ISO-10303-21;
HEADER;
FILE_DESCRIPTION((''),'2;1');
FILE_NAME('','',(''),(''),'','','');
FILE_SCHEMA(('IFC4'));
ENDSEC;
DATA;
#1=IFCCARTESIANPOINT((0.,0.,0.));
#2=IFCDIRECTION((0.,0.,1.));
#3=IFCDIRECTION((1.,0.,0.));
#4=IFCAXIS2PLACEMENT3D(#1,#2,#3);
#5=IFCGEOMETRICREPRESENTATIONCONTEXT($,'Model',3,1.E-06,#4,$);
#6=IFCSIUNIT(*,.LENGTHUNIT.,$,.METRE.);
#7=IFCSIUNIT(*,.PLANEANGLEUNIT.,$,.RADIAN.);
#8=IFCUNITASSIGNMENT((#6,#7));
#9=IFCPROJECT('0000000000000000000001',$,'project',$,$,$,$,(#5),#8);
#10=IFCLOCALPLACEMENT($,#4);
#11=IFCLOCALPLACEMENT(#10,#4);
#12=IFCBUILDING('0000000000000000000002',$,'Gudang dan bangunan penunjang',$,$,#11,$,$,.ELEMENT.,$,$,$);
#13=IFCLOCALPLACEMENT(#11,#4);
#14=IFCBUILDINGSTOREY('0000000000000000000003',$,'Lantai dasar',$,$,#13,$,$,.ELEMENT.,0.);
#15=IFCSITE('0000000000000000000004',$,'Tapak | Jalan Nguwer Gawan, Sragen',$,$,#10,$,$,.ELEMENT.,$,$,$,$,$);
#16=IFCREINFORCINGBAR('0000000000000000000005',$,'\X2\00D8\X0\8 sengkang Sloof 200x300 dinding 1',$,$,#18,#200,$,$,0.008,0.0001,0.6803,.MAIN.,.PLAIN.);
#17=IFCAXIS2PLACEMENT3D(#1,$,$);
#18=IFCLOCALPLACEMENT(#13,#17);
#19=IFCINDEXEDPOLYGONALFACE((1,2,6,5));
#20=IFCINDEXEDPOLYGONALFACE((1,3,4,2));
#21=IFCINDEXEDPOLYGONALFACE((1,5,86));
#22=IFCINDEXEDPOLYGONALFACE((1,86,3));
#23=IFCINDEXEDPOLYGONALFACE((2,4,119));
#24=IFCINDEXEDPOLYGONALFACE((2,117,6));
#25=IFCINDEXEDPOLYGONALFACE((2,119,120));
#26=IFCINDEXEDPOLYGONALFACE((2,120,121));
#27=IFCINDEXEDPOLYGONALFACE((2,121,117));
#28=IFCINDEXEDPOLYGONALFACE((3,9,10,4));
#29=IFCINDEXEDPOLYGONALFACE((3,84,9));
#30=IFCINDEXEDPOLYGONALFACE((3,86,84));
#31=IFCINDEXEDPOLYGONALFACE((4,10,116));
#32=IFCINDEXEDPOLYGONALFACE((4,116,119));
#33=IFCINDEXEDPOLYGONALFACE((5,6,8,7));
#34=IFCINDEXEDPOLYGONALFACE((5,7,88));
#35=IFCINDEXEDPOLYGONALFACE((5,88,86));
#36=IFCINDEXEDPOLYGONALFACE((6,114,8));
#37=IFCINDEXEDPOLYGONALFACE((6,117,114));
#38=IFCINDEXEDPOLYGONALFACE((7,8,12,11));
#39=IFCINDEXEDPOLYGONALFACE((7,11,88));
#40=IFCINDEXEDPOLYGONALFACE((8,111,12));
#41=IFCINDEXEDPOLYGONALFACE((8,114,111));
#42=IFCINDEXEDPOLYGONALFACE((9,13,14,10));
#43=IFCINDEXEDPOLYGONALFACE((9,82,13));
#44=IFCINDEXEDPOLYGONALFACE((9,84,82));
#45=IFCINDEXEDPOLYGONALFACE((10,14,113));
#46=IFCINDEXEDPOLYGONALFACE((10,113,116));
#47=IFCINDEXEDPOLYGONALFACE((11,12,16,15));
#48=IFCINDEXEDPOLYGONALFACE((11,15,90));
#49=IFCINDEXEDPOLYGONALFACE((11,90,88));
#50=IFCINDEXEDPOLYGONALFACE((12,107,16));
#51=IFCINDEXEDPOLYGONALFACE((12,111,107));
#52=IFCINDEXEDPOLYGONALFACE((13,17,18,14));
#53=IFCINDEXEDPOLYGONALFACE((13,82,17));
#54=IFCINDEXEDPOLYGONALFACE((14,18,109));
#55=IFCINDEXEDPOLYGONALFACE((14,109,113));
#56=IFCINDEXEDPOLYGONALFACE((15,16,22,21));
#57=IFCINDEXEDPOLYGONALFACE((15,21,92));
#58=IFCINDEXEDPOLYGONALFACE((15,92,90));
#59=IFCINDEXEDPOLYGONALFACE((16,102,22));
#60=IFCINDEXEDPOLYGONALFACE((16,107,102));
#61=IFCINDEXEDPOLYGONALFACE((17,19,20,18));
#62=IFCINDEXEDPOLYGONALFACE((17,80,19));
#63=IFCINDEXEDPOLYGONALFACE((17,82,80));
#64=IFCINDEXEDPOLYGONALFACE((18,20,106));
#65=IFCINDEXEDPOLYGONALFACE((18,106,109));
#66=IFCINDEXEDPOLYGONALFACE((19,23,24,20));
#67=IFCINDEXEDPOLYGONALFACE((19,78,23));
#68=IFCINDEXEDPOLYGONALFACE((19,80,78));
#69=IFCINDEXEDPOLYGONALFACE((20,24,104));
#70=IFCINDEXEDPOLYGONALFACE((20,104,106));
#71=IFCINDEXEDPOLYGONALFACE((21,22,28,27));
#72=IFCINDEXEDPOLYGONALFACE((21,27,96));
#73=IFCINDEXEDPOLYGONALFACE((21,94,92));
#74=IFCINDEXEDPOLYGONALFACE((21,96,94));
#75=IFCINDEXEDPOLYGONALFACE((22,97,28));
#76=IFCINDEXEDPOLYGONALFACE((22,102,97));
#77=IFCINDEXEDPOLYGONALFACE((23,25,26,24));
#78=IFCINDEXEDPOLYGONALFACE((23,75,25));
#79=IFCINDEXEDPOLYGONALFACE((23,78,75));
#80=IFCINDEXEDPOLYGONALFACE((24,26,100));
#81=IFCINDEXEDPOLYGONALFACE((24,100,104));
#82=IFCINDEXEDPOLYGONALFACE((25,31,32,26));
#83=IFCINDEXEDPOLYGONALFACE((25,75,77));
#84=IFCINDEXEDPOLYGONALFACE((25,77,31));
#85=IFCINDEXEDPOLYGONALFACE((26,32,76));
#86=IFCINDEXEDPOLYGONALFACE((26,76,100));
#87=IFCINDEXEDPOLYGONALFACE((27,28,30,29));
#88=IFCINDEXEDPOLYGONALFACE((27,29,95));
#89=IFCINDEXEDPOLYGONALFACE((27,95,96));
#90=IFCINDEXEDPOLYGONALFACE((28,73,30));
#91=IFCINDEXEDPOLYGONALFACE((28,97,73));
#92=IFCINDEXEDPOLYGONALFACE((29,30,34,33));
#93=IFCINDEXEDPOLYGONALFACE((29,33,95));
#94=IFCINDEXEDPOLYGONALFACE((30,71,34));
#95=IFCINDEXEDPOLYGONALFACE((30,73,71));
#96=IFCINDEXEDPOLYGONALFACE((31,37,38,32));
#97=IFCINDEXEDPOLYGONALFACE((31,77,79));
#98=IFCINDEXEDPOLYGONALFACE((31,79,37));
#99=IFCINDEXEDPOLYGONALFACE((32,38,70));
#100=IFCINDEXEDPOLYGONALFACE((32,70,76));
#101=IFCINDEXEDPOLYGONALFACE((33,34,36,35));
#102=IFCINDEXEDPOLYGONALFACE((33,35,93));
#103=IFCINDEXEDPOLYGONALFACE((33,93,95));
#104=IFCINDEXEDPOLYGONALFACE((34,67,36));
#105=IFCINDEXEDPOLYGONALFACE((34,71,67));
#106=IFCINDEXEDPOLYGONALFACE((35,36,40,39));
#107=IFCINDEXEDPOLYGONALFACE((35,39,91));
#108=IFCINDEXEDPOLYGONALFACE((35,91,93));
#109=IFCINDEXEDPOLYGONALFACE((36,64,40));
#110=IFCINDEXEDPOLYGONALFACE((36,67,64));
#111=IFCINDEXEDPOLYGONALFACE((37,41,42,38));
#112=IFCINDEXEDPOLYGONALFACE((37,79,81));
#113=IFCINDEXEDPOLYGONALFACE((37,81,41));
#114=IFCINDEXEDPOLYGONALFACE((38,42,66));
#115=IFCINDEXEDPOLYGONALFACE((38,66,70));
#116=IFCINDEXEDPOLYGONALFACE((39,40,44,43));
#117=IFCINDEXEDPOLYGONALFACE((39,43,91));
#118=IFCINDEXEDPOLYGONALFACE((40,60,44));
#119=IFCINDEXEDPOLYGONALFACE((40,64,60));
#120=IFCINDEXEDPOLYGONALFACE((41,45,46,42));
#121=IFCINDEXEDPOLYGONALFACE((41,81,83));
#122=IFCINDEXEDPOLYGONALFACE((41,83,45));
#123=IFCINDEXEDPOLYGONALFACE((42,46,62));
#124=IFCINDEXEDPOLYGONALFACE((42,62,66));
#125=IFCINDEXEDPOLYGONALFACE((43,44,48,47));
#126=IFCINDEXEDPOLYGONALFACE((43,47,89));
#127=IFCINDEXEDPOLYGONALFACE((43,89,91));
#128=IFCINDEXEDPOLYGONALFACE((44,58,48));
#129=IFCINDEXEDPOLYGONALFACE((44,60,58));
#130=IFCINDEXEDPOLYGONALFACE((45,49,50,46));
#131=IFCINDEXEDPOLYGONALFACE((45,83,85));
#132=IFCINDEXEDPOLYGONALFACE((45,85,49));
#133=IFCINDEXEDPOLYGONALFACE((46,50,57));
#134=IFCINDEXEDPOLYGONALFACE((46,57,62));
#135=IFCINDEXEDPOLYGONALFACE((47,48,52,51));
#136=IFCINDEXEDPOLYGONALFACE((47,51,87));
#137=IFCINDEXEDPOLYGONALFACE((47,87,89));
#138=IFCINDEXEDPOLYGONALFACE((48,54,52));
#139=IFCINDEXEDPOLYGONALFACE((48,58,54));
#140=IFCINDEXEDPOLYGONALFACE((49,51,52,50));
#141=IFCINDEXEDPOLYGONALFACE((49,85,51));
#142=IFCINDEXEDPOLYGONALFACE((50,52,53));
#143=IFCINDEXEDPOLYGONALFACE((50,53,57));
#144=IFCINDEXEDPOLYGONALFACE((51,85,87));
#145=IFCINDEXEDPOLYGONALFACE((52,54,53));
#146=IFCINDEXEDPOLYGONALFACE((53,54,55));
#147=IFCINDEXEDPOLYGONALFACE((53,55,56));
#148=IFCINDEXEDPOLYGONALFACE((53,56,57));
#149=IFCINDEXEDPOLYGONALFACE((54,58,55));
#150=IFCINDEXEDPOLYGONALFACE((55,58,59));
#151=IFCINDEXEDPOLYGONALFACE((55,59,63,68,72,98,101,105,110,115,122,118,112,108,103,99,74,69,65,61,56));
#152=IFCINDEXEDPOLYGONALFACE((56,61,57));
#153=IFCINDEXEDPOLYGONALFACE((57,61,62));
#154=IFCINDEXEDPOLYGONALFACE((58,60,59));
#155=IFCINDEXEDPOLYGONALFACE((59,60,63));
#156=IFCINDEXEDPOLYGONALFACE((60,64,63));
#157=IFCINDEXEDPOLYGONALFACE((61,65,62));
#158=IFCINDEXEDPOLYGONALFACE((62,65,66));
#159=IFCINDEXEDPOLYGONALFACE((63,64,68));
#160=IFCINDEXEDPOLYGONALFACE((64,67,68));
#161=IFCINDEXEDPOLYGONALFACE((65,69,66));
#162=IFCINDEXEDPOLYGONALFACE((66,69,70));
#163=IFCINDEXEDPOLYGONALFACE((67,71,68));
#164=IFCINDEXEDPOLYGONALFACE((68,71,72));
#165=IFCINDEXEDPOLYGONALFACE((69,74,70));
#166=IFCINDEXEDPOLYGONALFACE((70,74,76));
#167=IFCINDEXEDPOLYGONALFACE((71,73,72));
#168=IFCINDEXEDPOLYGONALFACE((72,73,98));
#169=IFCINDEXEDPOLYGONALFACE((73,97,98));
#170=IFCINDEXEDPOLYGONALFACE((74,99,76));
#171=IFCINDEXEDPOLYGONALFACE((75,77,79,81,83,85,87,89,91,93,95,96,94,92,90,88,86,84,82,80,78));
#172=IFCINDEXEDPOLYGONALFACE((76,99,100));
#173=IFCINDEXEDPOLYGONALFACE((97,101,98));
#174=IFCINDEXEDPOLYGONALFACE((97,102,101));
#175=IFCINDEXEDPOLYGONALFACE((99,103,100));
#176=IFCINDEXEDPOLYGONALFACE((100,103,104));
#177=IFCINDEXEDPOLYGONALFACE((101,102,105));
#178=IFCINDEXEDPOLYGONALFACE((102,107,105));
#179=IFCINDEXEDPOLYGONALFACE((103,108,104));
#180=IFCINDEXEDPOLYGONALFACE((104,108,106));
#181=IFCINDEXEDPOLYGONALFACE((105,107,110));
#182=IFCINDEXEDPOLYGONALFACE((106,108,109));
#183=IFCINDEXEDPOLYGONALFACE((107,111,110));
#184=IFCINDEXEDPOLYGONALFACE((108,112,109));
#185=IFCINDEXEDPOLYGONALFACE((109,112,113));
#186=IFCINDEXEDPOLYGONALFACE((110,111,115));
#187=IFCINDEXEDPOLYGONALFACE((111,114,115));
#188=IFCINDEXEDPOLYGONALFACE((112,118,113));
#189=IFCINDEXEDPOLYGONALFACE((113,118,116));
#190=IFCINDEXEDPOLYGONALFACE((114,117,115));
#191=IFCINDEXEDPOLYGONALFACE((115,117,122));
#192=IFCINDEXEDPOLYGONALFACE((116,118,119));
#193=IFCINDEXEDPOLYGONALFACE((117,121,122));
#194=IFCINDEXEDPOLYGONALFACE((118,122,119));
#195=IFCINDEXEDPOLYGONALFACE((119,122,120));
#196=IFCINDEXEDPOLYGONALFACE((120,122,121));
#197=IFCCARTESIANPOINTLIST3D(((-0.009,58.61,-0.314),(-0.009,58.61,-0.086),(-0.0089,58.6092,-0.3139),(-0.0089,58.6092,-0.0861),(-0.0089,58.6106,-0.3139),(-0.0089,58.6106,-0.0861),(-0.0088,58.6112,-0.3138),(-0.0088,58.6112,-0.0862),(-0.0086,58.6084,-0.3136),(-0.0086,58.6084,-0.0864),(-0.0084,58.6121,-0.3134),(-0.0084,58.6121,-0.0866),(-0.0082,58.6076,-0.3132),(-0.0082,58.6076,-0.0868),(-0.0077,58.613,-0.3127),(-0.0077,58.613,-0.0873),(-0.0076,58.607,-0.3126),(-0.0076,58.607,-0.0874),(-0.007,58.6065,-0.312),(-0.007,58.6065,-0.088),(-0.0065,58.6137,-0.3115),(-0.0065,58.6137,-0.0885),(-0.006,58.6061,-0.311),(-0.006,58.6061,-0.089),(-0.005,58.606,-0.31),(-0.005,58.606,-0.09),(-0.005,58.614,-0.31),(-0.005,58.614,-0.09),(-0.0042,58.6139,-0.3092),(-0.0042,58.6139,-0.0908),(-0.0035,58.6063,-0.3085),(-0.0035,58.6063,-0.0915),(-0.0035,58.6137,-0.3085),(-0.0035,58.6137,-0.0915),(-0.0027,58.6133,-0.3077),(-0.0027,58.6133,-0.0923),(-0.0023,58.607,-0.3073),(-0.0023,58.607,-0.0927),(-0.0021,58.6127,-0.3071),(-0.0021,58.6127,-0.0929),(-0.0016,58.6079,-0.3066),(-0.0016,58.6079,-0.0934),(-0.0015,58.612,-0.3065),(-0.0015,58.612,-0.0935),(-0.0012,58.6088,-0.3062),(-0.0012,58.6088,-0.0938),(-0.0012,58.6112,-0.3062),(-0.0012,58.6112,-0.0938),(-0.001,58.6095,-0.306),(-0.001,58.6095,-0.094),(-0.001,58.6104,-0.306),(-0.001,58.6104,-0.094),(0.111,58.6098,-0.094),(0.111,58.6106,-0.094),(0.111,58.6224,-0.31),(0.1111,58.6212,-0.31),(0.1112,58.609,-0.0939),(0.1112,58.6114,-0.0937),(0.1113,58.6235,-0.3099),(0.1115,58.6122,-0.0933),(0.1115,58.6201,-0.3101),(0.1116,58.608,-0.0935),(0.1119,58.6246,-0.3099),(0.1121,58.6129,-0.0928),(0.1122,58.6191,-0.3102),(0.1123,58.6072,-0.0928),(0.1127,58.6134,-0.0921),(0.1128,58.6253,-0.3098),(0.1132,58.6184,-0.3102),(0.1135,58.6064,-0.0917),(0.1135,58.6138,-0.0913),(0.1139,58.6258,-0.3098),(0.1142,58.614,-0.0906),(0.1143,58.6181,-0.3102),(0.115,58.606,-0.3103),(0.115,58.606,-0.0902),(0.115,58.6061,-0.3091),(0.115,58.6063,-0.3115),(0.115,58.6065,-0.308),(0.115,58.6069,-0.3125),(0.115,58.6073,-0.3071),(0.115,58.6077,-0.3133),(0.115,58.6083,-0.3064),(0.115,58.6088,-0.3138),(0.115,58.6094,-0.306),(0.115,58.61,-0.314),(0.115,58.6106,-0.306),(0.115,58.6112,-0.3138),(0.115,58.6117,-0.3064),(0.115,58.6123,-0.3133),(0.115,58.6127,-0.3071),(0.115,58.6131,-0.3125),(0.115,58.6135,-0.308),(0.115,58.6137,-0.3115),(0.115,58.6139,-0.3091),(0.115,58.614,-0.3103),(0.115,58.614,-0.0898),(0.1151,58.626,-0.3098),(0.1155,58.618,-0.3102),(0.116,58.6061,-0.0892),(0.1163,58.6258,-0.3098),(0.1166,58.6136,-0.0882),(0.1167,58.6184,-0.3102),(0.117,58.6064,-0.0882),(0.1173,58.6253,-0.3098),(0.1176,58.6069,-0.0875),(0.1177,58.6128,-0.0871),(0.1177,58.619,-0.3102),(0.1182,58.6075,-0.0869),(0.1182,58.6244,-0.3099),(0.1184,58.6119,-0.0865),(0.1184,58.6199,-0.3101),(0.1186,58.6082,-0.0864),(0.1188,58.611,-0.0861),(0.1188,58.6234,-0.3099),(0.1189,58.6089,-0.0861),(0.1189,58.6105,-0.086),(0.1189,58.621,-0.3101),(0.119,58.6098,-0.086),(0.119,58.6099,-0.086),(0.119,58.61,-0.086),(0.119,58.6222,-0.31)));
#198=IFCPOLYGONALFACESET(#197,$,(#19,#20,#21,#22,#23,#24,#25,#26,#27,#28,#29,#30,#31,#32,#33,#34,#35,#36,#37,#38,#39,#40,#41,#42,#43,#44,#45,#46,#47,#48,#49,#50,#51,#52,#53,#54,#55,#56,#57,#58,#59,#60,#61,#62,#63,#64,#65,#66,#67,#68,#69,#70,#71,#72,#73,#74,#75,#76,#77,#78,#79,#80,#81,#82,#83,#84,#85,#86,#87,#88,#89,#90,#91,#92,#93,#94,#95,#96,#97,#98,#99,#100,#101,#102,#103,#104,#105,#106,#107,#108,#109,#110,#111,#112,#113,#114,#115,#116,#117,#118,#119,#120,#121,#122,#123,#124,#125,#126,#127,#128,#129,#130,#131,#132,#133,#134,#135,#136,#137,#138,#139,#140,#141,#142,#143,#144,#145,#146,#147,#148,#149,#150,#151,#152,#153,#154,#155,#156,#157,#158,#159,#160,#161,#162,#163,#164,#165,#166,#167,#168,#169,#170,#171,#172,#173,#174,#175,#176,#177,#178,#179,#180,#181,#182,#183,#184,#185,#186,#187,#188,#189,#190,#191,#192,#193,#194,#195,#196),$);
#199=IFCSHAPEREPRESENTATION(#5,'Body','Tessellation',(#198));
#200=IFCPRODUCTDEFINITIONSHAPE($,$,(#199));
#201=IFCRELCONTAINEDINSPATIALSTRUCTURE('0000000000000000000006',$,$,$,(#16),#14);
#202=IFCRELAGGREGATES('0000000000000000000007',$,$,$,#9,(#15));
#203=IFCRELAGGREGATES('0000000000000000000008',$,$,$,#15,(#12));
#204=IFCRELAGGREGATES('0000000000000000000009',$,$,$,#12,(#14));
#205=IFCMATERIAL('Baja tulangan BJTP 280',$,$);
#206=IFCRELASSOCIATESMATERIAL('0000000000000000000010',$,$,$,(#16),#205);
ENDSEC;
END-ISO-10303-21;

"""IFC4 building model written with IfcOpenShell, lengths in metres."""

from ifc_helpers import new_model, entity, si_unit, origin_with_axes, place, context, project, spatial, material, element, save


model = new_model("IFC4")

# Units and contexts
model_context = context("Model", 3, precision=1e-06, world=origin_with_axes())
ifc_project = project(units=[si_unit("LENGTHUNIT", "METRE"), si_unit("PLANEANGLEUNIT", "RADIAN")], contexts=[model_context])

# Site, building, storey
site_placement = place(None, origin_with_axes())
site = spatial("IfcSite", under=ifc_project, at=site_placement, Name="Tapak | Jalan Nguwer Gawan, Sragen", CompositionType="ELEMENT")
building_placement = place(site_placement, origin_with_axes())
building = spatial("IfcBuilding", under=site, at=building_placement, Name="Gudang dan bangunan penunjang", CompositionType="ELEMENT")
storey_placement = place(building_placement, origin_with_axes())
storey = spatial("IfcBuildingStorey", under=building, at=storey_placement, Name="Lantai dasar", CompositionType="ELEMENT", Elevation=0.0)

# Shared definitions
placement = place(None, origin_with_axes())

# Reinforcing bar
ifc_material_1 = material(Name="Baja tulangan BJTP 280")
element("IfcReinforcingBar", 1, at=placement, inside=storey, material=ifc_material_1, Name="Ø8 sengkang Sloof 200x300 dinding 1", BarLength=0.6803, BarSurface="PLAIN", CrossSectionArea=0.0001, NominalDiameter=0.008, PredefinedType="MAIN", context=model_context, shape_type="AdvancedSweptSolid", body=[
    entity("IfcSweptDiskSolid", entity("IfcPolyline", [entity("IfcCartesianPoint", [0.115, 58.61, -0.31]), entity("IfcCartesianPoint", [-0.005, 58.61, -0.31]), entity("IfcCartesianPoint", [-0.005, 58.61, -0.09]), entity("IfcCartesianPoint", [0.115, 58.61, -0.09]), entity("IfcCartesianPoint", [0.115, 58.622, -0.31])]), 0.004),
])

save(model, "model.ifc")
